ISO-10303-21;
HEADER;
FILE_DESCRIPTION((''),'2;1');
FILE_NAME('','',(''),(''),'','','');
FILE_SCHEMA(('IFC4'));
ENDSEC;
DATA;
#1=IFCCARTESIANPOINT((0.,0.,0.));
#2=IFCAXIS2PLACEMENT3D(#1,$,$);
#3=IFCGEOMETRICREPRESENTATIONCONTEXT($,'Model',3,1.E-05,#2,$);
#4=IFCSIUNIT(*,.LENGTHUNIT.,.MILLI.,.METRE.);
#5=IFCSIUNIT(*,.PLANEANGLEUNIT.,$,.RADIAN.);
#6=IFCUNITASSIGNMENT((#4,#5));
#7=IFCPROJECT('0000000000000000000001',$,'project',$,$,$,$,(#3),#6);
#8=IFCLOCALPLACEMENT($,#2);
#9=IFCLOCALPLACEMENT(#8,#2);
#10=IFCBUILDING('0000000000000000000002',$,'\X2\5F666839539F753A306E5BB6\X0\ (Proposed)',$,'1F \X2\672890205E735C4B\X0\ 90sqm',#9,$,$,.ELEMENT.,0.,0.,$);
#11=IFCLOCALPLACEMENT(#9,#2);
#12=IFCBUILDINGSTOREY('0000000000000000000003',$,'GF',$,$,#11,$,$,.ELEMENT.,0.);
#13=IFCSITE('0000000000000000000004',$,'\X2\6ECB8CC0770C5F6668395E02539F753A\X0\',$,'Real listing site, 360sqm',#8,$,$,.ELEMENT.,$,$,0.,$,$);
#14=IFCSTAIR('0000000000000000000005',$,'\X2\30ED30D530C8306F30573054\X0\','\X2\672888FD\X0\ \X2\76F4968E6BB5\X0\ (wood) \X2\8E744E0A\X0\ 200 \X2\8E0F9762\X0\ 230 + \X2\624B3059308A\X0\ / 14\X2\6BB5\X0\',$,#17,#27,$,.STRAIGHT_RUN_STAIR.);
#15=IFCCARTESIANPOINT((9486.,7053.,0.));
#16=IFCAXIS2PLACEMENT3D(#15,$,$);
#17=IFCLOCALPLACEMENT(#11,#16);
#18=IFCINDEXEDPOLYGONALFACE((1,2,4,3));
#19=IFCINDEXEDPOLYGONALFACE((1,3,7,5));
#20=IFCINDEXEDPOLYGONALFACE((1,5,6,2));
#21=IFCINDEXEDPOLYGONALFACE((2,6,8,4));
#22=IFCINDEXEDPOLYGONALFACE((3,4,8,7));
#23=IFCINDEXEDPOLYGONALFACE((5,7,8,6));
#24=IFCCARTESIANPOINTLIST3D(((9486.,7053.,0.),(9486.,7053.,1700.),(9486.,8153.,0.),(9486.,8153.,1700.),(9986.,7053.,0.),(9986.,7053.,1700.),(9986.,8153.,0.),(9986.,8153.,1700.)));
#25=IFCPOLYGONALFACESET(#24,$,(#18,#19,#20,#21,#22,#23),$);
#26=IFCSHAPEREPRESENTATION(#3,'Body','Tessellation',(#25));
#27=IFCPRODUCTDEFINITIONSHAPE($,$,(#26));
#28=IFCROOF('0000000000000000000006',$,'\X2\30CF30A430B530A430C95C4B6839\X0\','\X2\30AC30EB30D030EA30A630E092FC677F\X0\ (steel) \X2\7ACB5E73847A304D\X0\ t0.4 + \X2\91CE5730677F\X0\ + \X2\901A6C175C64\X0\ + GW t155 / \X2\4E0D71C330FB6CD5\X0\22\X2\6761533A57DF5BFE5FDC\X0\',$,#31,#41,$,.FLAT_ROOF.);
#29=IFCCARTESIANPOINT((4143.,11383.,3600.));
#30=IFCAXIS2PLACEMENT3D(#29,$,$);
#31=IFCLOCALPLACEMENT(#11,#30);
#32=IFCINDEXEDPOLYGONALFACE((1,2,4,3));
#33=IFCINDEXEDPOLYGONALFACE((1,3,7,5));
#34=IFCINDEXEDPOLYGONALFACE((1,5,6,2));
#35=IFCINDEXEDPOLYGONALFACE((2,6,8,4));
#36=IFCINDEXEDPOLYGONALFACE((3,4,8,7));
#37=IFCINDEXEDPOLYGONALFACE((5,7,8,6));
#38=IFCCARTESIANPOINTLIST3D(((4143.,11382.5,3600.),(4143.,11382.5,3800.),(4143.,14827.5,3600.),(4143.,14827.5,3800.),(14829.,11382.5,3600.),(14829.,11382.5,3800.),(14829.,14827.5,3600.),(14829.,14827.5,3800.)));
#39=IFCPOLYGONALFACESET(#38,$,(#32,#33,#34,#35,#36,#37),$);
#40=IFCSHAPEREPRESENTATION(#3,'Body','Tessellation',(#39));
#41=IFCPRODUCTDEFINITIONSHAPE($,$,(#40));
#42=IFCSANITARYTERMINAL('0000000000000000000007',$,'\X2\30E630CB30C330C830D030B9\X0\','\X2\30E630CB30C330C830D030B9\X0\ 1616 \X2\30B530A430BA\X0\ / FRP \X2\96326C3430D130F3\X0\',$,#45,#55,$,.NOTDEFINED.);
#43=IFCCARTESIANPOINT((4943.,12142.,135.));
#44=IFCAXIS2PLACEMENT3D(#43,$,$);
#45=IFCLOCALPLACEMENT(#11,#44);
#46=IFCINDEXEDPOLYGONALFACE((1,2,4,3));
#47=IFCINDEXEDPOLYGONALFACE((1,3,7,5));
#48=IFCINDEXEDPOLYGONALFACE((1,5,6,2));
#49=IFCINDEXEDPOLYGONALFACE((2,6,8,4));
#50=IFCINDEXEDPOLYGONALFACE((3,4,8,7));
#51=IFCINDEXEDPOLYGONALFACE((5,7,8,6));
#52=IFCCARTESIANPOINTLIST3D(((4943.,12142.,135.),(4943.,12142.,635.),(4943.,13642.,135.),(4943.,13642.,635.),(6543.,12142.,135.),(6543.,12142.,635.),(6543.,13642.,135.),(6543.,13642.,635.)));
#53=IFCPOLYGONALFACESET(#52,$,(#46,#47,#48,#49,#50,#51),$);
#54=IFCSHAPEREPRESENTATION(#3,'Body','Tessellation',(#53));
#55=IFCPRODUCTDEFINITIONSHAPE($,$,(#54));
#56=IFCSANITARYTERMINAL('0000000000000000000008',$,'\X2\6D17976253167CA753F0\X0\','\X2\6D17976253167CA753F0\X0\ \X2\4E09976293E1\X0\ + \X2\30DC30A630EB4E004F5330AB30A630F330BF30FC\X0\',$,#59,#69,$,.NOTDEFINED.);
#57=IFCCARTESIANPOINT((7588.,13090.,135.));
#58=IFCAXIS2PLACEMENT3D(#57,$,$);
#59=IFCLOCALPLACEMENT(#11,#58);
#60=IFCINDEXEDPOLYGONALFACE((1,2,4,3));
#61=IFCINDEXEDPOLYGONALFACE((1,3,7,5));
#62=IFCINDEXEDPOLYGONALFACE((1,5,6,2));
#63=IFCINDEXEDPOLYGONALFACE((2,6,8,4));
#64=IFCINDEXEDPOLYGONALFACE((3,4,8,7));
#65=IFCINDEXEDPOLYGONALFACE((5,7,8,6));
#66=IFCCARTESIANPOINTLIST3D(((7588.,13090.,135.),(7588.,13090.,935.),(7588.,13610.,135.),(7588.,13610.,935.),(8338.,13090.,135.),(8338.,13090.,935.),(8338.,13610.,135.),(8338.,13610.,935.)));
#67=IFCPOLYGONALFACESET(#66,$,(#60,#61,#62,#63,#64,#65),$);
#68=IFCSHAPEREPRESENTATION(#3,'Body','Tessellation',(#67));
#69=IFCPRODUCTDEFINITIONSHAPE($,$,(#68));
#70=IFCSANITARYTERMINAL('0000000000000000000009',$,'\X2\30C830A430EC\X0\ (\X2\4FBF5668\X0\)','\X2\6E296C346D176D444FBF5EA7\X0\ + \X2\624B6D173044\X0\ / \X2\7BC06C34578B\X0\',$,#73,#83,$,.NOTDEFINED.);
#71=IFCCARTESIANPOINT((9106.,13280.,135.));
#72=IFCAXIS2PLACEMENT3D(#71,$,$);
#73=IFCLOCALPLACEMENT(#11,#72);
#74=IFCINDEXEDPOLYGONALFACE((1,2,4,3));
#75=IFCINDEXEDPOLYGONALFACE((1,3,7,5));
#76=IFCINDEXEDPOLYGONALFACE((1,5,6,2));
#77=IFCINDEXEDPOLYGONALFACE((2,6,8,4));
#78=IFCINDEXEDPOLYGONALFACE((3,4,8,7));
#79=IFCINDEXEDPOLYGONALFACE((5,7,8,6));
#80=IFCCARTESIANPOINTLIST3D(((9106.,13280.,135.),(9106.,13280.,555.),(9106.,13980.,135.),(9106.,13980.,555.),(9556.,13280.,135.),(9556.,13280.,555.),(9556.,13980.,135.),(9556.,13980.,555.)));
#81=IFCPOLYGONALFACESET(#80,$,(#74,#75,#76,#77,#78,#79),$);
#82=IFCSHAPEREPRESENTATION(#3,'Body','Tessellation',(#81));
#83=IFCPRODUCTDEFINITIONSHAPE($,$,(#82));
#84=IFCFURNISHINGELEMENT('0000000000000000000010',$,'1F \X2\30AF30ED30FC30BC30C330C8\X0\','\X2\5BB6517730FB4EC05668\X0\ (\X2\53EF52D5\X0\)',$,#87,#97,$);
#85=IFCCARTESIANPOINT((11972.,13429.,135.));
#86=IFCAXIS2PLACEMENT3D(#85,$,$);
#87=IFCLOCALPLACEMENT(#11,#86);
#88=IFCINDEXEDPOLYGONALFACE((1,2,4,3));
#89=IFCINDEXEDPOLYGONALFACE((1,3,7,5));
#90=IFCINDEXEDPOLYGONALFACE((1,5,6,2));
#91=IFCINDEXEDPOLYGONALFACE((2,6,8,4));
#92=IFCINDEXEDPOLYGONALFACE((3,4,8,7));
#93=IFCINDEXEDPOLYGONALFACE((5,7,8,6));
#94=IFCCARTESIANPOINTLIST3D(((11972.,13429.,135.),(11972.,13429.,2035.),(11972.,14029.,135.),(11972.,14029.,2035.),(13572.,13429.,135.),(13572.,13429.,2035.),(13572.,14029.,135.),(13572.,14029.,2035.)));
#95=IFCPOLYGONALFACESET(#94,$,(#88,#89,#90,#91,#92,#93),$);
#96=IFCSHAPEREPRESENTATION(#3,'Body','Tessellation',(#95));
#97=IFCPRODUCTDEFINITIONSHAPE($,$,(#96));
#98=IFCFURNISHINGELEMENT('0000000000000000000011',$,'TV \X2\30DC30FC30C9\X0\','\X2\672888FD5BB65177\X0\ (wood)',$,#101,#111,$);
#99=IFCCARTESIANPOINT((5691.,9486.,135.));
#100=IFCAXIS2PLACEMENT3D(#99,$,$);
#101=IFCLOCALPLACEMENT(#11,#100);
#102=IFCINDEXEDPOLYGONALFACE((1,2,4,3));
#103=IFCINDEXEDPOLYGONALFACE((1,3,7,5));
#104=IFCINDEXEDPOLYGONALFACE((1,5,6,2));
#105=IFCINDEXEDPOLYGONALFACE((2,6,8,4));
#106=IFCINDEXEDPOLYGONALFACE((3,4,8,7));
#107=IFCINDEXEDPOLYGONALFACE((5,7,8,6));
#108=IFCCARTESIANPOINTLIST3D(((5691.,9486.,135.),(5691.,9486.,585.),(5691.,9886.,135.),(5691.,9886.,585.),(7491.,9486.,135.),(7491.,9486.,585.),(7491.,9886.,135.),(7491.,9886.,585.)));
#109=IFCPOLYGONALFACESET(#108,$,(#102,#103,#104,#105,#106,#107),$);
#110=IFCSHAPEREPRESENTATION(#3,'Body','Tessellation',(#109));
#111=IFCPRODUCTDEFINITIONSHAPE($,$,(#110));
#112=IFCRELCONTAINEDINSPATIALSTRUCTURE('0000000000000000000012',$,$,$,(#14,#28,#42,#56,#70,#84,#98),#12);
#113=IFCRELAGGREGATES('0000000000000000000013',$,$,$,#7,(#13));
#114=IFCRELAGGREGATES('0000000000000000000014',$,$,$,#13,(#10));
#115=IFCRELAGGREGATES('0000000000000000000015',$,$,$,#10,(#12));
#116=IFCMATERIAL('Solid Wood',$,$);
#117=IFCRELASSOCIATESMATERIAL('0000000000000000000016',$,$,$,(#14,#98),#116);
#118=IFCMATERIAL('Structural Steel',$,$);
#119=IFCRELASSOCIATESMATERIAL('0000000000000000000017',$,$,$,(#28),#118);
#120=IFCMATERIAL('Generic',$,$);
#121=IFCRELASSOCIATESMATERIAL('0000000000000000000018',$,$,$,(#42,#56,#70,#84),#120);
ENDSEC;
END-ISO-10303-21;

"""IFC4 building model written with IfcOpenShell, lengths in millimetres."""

from ifc_helpers import new_model, si_unit, frame, frame_2d, origin, place, context, project, spatial, rectangle, extrude, material, element, save


model = new_model("IFC4")

# Units and contexts
model_context = context("Model", 3, precision=1e-05, world=origin())
ifc_project = project(units=[si_unit("LENGTHUNIT", "METRE", prefix="MILLI"), si_unit("PLANEANGLEUNIT", "RADIAN")], contexts=[model_context])

# Site, building, storey
site_placement = place(None, origin())
site = spatial("IfcSite", under=ifc_project, at=site_placement, Name="滋賀県彦根市原町", ObjectType="Real listing site, 360sqm", CompositionType="ELEMENT", RefElevation=0.0)
building_placement = place(site_placement, origin())
building = spatial("IfcBuilding", under=site, at=building_placement, Name="彦根原町の家 (Proposed)", ObjectType="1F 木造平屋 90sqm", CompositionType="ELEMENT", ElevationOfRefHeight=0.0, ElevationOfTerrain=0.0)
storey_placement = place(building_placement, origin())
storey = spatial("IfcBuildingStorey", under=building, at=storey_placement, Name="GF", CompositionType="ELEMENT", Elevation=0.0)

# Shared definitions
ifc_material_1 = material(Name="Solid Wood")

# Stair
stair_placement = place(storey_placement, frame((9486.0, 7053.0, 0.0)))
element("IfcStair", 1, at=stair_placement, inside=storey, material=ifc_material_1, Name="ロフトはしご", Description="木製 直階段 (wood) 蹴上 200 踏面 230 + 手すり / 14段", PredefinedType="STRAIGHT_RUN_STAIR", context=model_context, shape_type="SweptSolid", body=[
    extrude(rectangle(XDim=500.0, YDim=1100.0, at=frame_2d((250.0, 550.0))), frame((9486.0, 7053.0, 0.0)), (0.0, 0.0, 1.0), 1700.0),
])

# Roof
ifc_material_2 = material(Name="Structural Steel")
roof_placement = place(storey_placement, frame((4143.0, 11383.0, 3600.0)))
element("IfcRoof", 2, at=roof_placement, inside=storey, material=ifc_material_2, Name="ハイサイド屋根", Description="ガルバリウム鋼板 (steel) 立平葺き t0.4 + 野地板 + 通気層 + GW t155 / 不燃・法22条区域対応", PredefinedType="FLAT_ROOF", context=model_context, shape_type="SweptSolid", body=[
    extrude(rectangle(XDim=10686.0, YDim=3445.0, at=frame_2d((5343.0, 1722.0))), frame((4143.0, 11383.0, 3600.0)), (0.0, 0.0, 1.0), 200.0),
])

# Sanitary terminals
ifc_material_3 = material(Name="Generic")
sanitary_terminal_1_placement = place(storey_placement, frame((4943.0, 12142.0, 135.0)))
element("IfcSanitaryTerminal", 3, at=sanitary_terminal_1_placement, inside=storey, material=ifc_material_3, Name="ユニットバス", Description="ユニットバス 1616 サイズ / FRP 防水パン", PredefinedType="NOTDEFINED", context=model_context, shape_type="SweptSolid", body=[
    extrude(rectangle(XDim=1600.0, YDim=1500.0, at=frame_2d((800.0, 750.0))), frame((4943.0, 12142.0, 135.0)), (0.0, 0.0, 1.0), 500.0),
])
sanitary_terminal_2_placement = place(storey_placement, frame((7588.0, 13090.0, 135.0)))
element("IfcSanitaryTerminal", 4, at=sanitary_terminal_2_placement, inside=storey, material=ifc_material_3, Name="洗面化粧台", Description="洗面化粧台 三面鏡 + ボウル一体カウンター", PredefinedType="NOTDEFINED", context=model_context, shape_type="SweptSolid", body=[
    extrude(rectangle(XDim=750.0, YDim=520.0, at=frame_2d((375.0, 260.0))), frame((7588.0, 13090.0, 135.0)), (0.0, 0.0, 1.0), 800.0),
])
sanitary_terminal_3_placement = place(storey_placement, frame((9106.0, 13280.0, 135.0)))
element("IfcSanitaryTerminal", 5, at=sanitary_terminal_3_placement, inside=storey, material=ifc_material_3, Name="トイレ (便器)", Description="温水洗浄便座 + 手洗い / 節水型", PredefinedType="NOTDEFINED", context=model_context, shape_type="SweptSolid", body=[
    extrude(rectangle(XDim=450.0, YDim=700.0, at=frame_2d((225.0, 350.0))), frame((9106.0, 13280.0, 135.0)), (0.0, 0.0, 1.0), 420.0),
])

# Furnishing elements
furnishing_1_placement = place(storey_placement, frame((11972.0, 13429.0, 135.0)))
element("IfcFurnishingElement", 6, at=furnishing_1_placement, inside=storey, material=ifc_material_3, Name="1F クローゼット", Description="家具・什器 (可動)", context=model_context, shape_type="SweptSolid", body=[
    extrude(rectangle(XDim=1600.0, YDim=600.0, at=frame_2d((800.0, 300.0))), frame((11972.0, 13429.0, 135.0)), (0.0, 0.0, 1.0), 1900.0),
])
furnishing_2_placement = place(storey_placement, frame((5691.0, 9486.0, 135.0)))
element("IfcFurnishingElement", 7, at=furnishing_2_placement, inside=storey, material=ifc_material_1, Name="TV ボード", Description="木製家具 (wood)", context=model_context, shape_type="SweptSolid", body=[
    extrude(rectangle(XDim=1800.0, YDim=400.0, at=frame_2d((900.0, 200.0))), frame((5691.0, 9486.0, 135.0)), (0.0, 0.0, 1.0), 450.0),
])

save(model, "model.ifc")
